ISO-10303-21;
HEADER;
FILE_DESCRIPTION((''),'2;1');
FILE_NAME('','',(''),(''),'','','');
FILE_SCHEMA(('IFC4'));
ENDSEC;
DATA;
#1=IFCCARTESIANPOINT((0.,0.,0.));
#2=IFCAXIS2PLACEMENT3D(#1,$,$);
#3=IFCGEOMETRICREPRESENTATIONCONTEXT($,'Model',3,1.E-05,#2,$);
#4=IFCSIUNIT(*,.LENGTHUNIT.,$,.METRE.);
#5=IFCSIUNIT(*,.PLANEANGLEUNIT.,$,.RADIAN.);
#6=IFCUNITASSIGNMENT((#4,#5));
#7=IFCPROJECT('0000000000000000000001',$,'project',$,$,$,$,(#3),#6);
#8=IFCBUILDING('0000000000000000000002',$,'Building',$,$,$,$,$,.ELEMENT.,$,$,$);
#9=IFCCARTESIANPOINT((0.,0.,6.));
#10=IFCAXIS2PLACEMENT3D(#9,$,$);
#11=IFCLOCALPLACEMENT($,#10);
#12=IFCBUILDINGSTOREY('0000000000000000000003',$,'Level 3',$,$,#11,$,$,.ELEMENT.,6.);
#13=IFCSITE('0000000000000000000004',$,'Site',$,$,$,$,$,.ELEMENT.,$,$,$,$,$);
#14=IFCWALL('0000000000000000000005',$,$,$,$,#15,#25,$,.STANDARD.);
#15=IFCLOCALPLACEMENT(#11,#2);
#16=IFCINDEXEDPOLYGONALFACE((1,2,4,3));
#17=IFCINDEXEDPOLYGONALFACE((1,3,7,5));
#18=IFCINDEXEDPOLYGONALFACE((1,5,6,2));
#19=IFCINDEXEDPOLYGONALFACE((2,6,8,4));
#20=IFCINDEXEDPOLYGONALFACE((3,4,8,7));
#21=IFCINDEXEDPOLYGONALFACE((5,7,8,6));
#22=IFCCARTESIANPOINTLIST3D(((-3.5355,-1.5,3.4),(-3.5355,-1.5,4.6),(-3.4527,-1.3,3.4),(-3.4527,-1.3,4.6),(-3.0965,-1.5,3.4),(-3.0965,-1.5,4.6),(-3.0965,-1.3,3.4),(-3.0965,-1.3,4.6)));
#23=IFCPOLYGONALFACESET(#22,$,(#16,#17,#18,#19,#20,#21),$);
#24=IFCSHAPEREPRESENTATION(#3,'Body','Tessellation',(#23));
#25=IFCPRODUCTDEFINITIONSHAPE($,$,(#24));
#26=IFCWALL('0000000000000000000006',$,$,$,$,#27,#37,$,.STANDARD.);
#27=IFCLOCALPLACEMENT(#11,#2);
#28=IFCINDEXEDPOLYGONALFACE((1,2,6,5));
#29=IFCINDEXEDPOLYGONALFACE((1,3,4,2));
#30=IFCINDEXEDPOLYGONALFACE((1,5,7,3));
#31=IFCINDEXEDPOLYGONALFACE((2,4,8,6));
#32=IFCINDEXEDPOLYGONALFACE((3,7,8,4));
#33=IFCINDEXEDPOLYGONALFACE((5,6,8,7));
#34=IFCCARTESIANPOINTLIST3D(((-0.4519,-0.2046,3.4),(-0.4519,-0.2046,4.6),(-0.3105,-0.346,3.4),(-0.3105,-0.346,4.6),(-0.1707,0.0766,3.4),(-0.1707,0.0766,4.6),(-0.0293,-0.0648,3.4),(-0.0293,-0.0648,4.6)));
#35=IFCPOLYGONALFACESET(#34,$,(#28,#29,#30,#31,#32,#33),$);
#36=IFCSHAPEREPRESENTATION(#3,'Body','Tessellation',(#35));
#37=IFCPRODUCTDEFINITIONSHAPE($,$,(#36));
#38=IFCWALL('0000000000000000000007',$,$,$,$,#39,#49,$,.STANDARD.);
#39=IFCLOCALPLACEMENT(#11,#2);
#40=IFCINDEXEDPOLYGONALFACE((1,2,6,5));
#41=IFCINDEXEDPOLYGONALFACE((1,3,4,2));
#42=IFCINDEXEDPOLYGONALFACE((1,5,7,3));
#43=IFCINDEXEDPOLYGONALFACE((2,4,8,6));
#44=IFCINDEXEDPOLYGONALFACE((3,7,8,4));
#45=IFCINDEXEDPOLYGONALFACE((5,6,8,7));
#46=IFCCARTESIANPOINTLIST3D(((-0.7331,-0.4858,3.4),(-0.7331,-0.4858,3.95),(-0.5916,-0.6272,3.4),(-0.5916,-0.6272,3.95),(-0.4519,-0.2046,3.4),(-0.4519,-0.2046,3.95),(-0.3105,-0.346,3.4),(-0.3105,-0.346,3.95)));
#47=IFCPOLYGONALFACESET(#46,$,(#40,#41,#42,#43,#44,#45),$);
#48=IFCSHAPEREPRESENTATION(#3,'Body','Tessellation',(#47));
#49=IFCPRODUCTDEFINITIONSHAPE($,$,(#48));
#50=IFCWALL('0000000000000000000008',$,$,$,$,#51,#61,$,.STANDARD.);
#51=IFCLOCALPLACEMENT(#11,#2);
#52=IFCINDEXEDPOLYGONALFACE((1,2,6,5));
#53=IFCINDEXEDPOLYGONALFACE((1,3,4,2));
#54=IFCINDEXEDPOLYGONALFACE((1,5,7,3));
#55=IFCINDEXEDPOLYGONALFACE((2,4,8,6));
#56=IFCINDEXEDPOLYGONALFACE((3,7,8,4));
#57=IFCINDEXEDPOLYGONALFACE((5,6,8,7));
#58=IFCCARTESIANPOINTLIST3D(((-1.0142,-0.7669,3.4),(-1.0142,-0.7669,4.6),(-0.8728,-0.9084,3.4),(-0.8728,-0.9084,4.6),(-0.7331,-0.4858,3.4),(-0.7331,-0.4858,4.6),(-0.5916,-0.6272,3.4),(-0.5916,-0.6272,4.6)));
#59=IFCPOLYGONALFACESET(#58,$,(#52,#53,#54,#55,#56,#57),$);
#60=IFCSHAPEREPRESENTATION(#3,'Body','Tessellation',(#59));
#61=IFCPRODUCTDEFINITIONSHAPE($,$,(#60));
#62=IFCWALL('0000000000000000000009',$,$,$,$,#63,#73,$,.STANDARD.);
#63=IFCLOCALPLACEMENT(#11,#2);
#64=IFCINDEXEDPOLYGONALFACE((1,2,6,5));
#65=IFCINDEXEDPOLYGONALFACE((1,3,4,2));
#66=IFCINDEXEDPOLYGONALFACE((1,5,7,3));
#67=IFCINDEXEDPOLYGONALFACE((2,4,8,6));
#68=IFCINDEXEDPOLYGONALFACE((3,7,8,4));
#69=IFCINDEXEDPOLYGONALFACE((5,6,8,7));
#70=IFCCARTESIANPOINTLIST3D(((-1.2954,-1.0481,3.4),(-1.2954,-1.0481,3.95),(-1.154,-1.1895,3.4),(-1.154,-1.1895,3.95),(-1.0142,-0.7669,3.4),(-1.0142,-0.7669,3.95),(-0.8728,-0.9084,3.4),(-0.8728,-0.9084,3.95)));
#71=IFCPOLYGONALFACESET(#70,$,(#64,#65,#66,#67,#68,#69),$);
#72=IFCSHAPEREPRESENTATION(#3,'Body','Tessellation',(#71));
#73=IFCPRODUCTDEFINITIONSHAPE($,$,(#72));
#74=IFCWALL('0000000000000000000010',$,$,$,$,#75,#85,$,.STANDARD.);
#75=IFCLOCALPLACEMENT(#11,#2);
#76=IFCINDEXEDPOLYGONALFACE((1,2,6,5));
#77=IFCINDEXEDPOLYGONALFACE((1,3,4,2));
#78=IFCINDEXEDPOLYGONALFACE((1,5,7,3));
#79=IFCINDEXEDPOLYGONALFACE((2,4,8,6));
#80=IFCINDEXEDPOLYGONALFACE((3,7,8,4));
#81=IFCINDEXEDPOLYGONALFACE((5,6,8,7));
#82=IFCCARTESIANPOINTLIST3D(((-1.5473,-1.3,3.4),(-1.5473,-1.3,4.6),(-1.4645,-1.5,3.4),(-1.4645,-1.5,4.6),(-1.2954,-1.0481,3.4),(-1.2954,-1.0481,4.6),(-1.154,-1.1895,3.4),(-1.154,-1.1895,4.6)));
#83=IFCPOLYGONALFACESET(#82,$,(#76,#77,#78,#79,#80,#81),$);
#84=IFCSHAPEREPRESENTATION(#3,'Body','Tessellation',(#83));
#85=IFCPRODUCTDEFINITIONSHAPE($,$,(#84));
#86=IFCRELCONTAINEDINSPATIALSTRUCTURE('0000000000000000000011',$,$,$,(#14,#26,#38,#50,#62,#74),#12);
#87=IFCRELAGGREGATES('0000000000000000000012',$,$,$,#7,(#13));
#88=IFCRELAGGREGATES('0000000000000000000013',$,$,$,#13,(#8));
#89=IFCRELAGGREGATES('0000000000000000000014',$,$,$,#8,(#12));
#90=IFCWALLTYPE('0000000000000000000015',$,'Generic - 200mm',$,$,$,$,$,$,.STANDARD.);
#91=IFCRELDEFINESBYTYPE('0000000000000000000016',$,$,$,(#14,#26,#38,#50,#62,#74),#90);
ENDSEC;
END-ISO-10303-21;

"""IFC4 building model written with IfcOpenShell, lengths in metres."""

from ifc_helpers import new_model, si_unit, frame, frame_2d, origin, place, context, project, spatial, polyline, rectangle, outline, extrude, type_object, element, save


model = new_model("IFC4")

# Units and contexts
model_context = context("Model", 3, precision=1e-05, world=origin())
ifc_project = project(units=[si_unit("LENGTHUNIT", "METRE"), si_unit("PLANEANGLEUNIT", "RADIAN")], contexts=[model_context])

# Site, building, storey
site = spatial("IfcSite", under=ifc_project, Name="Site", CompositionType="ELEMENT")
building = spatial("IfcBuilding", under=site, Name="Building", CompositionType="ELEMENT")
storey_placement = place(None, frame((0.0, 0.0, 6.0)))
storey = spatial("IfcBuildingStorey", under=building, at=storey_placement, Name="Level 3", CompositionType="ELEMENT", Elevation=6.0)

# Walls
wall_type = type_object("IfcWallType", Name="Generic - 200mm", PredefinedType="STANDARD")
wall_1_placement = place(None, frame((-3.0965, -1.4, 9.4), z_axis=(0.0, 0.0, 1.0), x_axis=(-1.0, 0.0, 0.0)))
element("IfcWall", 1, at=wall_1_placement, inside=storey, type_object=wall_type, PredefinedType="STANDARD", context=model_context, shape_type="SweptSolid", body=[
    extrude(outline(polyline([(0.0, -0.1), (0.3562, -0.1), (0.4391, 0.1), (0.0, 0.1), (0.0, -0.1)])), origin(), (0.0, 0.0, 1.0), 1.2),
])
wall_2_placement = place(None, frame((-0.1, 0.0059, 9.4), z_axis=(0.0, 0.0, 1.0), x_axis=(-0.707107, -0.707107, 0.0)))
element("IfcWall", 2, at=wall_2_placement, inside=storey, type_object=wall_type, PredefinedType="STANDARD", context=model_context, shape_type="SweptSolid", body=[
    extrude(rectangle(XDim=0.3976, YDim=0.2, at=frame_2d((0.1988, 0.0))), origin(), (0.0, 0.0, 1.0), 1.2),
])
wall_3_placement = place(None, frame((-0.3812, -0.2753, 9.4), z_axis=(0.0, 0.0, 1.0), x_axis=(-0.707107, -0.707107, 0.0)))
element("IfcWall", 3, at=wall_3_placement, inside=storey, type_object=wall_type, PredefinedType="STANDARD", context=model_context, shape_type="SweptSolid", body=[
    extrude(rectangle(XDim=0.3976, YDim=0.2, at=frame_2d((0.1988, 0.0))), origin(), (0.0, 0.0, 1.0), 0.55),
])
wall_4_placement = place(None, frame((-0.6624, -0.5565, 9.4), z_axis=(0.0, 0.0, 1.0), x_axis=(-0.707107, -0.707107, 0.0)))
element("IfcWall", 4, at=wall_4_placement, inside=storey, type_object=wall_type, PredefinedType="STANDARD", context=model_context, shape_type="SweptSolid", body=[
    extrude(rectangle(XDim=0.3976, YDim=0.2, at=frame_2d((0.1988, 0.0))), origin(), (0.0, 0.0, 1.0), 1.2),
])
wall_5_placement = place(None, frame((-0.9435, -0.8376, 9.4), z_axis=(0.0, 0.0, 1.0), x_axis=(-0.707107, -0.707107, 0.0)))
element("IfcWall", 5, at=wall_5_placement, inside=storey, type_object=wall_type, PredefinedType="STANDARD", context=model_context, shape_type="SweptSolid", body=[
    extrude(rectangle(XDim=0.3976, YDim=0.2, at=frame_2d((0.1988, 0.0))), origin(), (0.0, 0.0, 1.0), 0.55),
])
wall_6_placement = place(None, frame((-1.2247, -1.1188, 9.4), z_axis=(0.0, 0.0, 1.0), x_axis=(-0.707107, -0.707107, 0.0)))
element("IfcWall", 6, at=wall_6_placement, inside=storey, type_object=wall_type, PredefinedType="STANDARD", context=model_context, shape_type="SweptSolid", body=[
    extrude(outline(polyline([(0.0, -0.1), (0.3562, -0.1), (0.4391, 0.1), (0.0, 0.1), (0.0, -0.1)])), origin(), (0.0, 0.0, 1.0), 1.2),
])

save(model, "model.ifc")
